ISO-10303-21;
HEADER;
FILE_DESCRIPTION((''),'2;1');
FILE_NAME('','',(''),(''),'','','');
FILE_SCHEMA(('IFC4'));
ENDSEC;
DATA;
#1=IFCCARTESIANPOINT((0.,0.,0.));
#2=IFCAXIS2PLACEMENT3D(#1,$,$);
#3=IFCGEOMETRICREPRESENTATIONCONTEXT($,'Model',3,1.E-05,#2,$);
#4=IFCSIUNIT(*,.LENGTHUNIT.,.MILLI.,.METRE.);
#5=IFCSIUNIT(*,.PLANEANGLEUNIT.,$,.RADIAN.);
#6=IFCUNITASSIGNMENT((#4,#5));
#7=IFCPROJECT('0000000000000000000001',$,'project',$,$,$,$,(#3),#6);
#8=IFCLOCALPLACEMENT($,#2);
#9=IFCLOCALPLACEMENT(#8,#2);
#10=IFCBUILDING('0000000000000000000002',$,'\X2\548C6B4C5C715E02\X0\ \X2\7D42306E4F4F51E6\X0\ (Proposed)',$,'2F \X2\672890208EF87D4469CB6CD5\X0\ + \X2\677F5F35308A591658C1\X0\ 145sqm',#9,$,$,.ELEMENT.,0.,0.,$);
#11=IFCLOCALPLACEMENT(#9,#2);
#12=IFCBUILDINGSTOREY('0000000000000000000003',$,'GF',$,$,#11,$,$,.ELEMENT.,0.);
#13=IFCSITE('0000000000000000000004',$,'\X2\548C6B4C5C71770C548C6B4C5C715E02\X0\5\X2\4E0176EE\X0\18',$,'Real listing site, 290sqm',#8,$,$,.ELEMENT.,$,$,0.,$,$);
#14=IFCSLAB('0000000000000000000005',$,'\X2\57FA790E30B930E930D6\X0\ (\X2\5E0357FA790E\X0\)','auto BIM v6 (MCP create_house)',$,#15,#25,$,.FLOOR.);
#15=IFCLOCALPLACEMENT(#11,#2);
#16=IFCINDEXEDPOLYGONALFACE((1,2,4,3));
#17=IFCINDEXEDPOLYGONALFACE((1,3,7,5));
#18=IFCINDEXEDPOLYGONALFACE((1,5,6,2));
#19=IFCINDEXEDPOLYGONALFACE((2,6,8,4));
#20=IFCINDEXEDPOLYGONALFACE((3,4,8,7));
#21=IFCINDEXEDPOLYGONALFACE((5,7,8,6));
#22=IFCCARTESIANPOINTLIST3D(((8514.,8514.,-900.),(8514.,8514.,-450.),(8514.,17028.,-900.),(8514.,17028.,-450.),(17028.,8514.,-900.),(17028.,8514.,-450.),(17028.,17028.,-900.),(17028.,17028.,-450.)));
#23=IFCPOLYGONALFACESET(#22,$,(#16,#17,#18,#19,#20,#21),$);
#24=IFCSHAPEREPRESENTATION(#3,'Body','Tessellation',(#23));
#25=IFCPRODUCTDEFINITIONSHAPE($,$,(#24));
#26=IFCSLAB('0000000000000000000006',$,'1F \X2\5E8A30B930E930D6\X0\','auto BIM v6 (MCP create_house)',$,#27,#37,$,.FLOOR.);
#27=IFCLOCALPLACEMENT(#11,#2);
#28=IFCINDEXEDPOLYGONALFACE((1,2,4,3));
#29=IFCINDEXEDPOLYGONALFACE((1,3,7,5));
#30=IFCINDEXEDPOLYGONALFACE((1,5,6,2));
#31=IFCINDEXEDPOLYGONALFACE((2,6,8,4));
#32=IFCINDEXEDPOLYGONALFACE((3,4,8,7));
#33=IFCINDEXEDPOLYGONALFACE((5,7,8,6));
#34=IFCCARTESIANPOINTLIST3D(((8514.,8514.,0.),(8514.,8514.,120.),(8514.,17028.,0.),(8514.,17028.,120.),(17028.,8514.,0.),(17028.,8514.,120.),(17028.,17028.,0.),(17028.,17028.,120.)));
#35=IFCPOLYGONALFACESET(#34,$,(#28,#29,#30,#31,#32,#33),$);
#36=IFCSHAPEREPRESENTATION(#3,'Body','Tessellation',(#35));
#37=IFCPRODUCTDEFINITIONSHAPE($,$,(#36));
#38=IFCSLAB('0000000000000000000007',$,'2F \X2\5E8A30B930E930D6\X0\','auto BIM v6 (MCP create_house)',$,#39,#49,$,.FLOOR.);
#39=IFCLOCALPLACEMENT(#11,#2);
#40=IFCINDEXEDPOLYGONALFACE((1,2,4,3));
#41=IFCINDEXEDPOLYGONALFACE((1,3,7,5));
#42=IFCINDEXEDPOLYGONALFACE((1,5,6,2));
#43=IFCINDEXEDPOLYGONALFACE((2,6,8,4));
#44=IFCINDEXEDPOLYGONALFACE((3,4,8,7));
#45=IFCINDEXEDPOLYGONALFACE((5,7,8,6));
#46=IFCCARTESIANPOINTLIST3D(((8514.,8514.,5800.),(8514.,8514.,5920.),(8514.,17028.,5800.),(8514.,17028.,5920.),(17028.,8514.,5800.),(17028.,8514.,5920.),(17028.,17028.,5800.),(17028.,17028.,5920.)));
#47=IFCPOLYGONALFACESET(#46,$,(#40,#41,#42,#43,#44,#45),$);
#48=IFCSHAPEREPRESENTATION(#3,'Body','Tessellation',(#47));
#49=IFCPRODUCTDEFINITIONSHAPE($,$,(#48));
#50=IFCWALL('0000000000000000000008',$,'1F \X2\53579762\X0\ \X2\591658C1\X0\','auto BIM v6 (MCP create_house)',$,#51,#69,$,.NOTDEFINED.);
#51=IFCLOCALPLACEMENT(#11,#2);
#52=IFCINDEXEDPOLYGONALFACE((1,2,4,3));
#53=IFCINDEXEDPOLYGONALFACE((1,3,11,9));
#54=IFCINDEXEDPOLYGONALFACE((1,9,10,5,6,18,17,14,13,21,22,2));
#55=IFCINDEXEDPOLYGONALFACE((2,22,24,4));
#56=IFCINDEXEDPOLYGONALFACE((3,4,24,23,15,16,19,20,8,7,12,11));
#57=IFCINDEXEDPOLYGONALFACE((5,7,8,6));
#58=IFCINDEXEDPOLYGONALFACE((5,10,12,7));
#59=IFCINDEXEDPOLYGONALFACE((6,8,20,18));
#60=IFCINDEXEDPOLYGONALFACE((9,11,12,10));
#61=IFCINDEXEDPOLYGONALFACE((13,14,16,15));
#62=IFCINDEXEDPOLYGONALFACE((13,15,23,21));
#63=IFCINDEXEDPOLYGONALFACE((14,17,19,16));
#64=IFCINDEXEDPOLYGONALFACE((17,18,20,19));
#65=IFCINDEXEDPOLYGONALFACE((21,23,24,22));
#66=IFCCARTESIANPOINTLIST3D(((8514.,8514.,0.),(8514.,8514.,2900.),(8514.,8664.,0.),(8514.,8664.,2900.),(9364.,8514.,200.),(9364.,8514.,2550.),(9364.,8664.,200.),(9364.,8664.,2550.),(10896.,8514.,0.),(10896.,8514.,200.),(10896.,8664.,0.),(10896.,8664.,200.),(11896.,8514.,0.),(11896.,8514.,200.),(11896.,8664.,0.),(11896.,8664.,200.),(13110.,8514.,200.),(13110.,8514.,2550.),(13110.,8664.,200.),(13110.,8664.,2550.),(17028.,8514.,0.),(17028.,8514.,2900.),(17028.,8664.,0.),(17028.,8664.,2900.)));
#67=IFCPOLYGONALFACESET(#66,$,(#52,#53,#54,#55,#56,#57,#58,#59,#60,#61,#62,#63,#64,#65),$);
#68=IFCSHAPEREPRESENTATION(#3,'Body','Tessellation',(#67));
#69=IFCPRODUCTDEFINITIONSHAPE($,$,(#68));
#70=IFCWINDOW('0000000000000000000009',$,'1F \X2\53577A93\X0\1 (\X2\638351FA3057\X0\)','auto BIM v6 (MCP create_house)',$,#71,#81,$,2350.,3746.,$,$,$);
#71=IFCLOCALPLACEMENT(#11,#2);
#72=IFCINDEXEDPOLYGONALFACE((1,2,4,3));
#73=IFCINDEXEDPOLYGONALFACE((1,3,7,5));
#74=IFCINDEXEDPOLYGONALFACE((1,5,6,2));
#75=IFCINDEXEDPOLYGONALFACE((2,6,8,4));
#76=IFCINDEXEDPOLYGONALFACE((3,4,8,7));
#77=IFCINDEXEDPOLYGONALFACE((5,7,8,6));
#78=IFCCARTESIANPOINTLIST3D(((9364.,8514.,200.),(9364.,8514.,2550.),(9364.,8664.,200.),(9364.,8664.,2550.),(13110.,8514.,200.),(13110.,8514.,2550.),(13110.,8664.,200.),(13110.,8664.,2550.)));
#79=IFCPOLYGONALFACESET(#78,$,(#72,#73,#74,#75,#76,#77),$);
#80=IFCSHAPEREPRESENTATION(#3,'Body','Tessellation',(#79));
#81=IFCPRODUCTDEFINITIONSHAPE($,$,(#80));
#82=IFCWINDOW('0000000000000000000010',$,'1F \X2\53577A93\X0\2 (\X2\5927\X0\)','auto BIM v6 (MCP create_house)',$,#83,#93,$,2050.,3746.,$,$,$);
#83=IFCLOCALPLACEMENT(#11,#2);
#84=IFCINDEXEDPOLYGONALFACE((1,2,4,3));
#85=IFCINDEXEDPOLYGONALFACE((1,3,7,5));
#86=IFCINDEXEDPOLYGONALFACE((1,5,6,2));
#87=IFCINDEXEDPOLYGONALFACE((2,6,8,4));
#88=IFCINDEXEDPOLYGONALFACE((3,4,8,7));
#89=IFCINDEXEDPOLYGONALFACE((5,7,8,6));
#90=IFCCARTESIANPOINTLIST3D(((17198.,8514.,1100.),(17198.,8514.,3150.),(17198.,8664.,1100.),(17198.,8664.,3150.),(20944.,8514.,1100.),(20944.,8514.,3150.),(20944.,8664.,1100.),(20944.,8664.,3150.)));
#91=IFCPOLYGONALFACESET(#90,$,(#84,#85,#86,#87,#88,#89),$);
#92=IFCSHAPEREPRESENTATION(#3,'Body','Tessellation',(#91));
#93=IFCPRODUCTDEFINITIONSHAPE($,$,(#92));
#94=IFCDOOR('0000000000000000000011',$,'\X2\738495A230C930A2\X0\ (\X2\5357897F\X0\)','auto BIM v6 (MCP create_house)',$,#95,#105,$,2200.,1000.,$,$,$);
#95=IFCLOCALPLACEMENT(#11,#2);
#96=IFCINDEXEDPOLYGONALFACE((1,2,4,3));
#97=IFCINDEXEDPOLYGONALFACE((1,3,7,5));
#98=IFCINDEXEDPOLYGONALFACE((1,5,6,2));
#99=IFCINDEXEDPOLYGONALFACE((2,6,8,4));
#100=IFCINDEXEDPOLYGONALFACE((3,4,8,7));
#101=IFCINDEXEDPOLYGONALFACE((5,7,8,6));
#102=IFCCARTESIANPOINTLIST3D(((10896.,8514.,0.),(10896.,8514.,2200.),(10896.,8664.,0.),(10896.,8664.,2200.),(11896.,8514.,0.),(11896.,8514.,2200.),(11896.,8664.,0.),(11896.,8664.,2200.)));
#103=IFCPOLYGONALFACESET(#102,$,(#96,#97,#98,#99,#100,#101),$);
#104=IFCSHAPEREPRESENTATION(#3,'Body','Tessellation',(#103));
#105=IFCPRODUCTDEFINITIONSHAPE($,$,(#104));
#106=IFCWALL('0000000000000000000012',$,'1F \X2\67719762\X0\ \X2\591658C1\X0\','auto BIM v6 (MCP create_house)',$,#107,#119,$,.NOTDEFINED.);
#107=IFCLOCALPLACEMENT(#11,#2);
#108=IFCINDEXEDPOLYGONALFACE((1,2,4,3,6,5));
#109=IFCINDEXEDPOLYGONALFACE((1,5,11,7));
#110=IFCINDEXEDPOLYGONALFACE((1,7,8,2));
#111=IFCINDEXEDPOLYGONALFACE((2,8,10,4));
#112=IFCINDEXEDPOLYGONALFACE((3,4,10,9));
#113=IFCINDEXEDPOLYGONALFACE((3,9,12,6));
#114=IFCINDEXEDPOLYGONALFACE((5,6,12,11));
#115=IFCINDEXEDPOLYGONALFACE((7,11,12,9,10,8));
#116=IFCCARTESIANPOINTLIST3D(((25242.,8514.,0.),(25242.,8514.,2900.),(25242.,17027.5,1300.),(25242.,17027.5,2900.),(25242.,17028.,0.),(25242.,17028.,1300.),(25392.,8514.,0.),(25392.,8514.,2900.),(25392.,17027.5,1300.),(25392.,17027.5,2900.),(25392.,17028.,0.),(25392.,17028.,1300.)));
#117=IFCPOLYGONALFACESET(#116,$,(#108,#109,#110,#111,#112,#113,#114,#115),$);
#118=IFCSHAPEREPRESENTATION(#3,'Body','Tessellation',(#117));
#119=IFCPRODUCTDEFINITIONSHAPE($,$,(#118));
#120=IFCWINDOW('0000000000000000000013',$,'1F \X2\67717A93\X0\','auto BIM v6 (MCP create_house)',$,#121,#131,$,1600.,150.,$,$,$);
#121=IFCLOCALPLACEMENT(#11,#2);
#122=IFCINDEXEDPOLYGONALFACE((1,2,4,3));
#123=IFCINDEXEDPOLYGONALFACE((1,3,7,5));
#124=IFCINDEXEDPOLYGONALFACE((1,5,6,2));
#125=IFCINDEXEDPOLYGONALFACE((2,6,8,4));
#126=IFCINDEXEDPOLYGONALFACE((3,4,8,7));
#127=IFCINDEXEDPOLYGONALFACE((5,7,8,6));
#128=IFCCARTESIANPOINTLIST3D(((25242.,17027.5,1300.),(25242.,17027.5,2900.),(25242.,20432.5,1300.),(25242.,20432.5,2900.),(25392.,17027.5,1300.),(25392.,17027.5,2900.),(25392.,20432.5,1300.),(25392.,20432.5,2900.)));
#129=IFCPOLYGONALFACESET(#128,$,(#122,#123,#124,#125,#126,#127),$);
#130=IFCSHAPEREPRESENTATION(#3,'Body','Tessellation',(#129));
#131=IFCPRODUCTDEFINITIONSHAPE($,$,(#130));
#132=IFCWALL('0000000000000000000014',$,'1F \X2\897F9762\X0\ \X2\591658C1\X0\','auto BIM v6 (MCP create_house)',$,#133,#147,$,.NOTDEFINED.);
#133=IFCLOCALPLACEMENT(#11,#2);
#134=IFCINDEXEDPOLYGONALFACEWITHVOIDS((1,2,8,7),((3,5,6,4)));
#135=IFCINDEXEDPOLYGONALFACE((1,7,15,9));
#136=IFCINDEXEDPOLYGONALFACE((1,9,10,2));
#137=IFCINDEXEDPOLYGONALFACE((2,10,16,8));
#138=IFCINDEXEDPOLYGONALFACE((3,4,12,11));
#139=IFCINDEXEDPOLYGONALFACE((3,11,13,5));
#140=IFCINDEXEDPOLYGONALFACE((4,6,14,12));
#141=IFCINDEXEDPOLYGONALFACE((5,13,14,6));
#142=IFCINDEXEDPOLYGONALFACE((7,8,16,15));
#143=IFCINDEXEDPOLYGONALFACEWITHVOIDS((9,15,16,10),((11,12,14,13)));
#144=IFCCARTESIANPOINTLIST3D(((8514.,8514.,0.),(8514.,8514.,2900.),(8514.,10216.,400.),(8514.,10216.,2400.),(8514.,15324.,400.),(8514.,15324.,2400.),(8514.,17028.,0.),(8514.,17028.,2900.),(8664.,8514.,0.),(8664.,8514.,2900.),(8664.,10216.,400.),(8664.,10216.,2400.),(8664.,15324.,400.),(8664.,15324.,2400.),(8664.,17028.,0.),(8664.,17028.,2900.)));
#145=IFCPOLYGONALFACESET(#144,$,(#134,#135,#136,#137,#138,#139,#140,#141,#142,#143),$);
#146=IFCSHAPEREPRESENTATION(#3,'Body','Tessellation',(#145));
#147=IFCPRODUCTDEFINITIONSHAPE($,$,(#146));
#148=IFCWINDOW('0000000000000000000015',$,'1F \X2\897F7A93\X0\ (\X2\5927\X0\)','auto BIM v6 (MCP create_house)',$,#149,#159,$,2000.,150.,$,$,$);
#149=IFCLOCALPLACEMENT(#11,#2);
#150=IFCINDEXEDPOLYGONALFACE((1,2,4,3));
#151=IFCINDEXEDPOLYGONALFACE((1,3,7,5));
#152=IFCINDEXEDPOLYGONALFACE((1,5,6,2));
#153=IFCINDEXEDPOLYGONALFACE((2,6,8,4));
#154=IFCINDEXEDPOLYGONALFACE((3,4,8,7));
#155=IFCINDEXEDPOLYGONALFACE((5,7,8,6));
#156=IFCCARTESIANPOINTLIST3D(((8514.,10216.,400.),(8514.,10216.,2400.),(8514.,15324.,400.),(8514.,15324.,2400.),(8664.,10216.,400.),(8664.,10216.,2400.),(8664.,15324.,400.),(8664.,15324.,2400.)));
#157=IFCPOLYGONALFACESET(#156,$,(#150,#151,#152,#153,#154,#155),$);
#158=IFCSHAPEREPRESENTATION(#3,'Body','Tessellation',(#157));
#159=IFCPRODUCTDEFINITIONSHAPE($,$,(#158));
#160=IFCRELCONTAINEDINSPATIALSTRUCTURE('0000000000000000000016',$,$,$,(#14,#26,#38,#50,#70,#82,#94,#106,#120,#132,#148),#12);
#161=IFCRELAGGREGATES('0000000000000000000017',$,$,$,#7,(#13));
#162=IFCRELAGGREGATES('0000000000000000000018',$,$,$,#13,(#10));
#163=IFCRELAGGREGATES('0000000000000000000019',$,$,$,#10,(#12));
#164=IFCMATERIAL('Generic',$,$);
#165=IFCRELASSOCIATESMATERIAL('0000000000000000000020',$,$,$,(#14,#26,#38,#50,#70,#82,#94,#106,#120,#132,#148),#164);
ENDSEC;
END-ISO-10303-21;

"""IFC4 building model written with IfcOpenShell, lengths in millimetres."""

from ifc_helpers import new_model, si_unit, frame, frame_2d, origin, place, context, project, spatial, rectangle, extrude, material, element, fill, save


model = new_model("IFC4")

# Units and contexts
model_context = context("Model", 3, precision=1e-05, world=origin())
ifc_project = project(units=[si_unit("LENGTHUNIT", "METRE", prefix="MILLI"), si_unit("PLANEANGLEUNIT", "RADIAN")], contexts=[model_context])

# Site, building, storey
site_placement = place(None, origin())
site = spatial("IfcSite", under=ifc_project, at=site_placement, Name="和歌山県和歌山市5丁目18", ObjectType="Real listing site, 290sqm", CompositionType="ELEMENT", RefElevation=0.0)
building_placement = place(site_placement, origin())
building = spatial("IfcBuilding", under=site, at=building_placement, Name="和歌山市 終の住処 (Proposed)", ObjectType="2F 木造軸組構法 + 板張り外壁 145sqm", CompositionType="ELEMENT", ElevationOfRefHeight=0.0, ElevationOfTerrain=0.0)
storey_placement = place(building_placement, origin())
storey = spatial("IfcBuildingStorey", under=building, at=storey_placement, Name="GF", CompositionType="ELEMENT", Elevation=0.0)

# Slabs
ifc_material = material(Name="Generic")
slab_1_placement = place(storey_placement, frame((4257.0, 4257.0, -450.0)))
element("IfcSlab", 1, at=slab_1_placement, inside=storey, material=ifc_material, Name="基礎スラブ (布基礎)", Description="auto BIM v6 (MCP create_house)", PredefinedType="FLOOR", context=model_context, shape_type="SweptSolid", body=[
    extrude(rectangle(XDim=8514.0, YDim=8514.0, at=frame_2d((4257.0, 4257.0))), frame((4257.0, 4257.0, -450.0)), (0.0, 0.0, 1.0), 450.0),
])
slab_2_placement = place(storey_placement, frame((4257.0, 4257.0, 0.0)))
element("IfcSlab", 2, at=slab_2_placement, inside=storey, material=ifc_material, Name="1F 床スラブ", Description="auto BIM v6 (MCP create_house)", PredefinedType="FLOOR", context=model_context, shape_type="SweptSolid", body=[
    extrude(rectangle(XDim=8514.0, YDim=8514.0, at=frame_2d((4257.0, 4257.0))), frame((4257.0, 4257.0, 0.0)), (0.0, 0.0, 1.0), 120.0),
])
slab_3_placement = place(storey_placement, frame((4257.0, 4257.0, 2900.0)))
element("IfcSlab", 3, at=slab_3_placement, inside=storey, material=ifc_material, Name="2F 床スラブ", Description="auto BIM v6 (MCP create_house)", PredefinedType="FLOOR", context=model_context, shape_type="SweptSolid", body=[
    extrude(rectangle(XDim=8514.0, YDim=8514.0, at=frame_2d((4257.0, 4257.0))), frame((4257.0, 4257.0, 2900.0)), (0.0, 0.0, 1.0), 120.0),
])

# Wall, openings, windows, door
wall_1_placement = place(storey_placement, frame((4257.0, 4257.0, 0.0)))
wall_1 = element("IfcWall", 4, at=wall_1_placement, inside=storey, material=ifc_material, Name="1F 南面 外壁", Description="auto BIM v6 (MCP create_house)", PredefinedType="NOTDEFINED", context=model_context, shape_type="SweptSolid", body=[
    extrude(rectangle(XDim=8514.0, YDim=150.0, at=frame_2d((4257.0, 75.0))), frame((4257.0, 4257.0, 0.0)), (0.0, 0.0, 1.0), 2900.0),
])
opening_1_placement = place(storey_placement, frame((4682.0, 4257.0, 100.0)))
opening_1 = element("IfcOpeningElement", 5, at=opening_1_placement, cuts=wall_1, PredefinedType="NOTDEFINED", context=model_context, shape_type="SweptSolid", body=[
    extrude(rectangle(XDim=3746.0, YDim=150.0, at=frame_2d((1873.0, 75.0))), frame((4682.0, 4257.0, 100.0)), (0.0, 0.0, 1.0), 2350.0),
])
opening_2_placement = place(storey_placement, frame((8599.0, 4257.0, 550.0)))
opening_2 = element("IfcOpeningElement", 6, at=opening_2_placement, cuts=wall_1, PredefinedType="NOTDEFINED", context=model_context, shape_type="SweptSolid", body=[
    extrude(rectangle(XDim=3746.0, YDim=150.0, at=frame_2d((1873.0, 75.0))), frame((8599.0, 4257.0, 550.0)), (0.0, 0.0, 1.0), 2050.0),
])
opening_3_placement = place(storey_placement, frame((5448.0, 4257.0, 0.0)))
opening_3 = element("IfcOpeningElement", 7, at=opening_3_placement, cuts=wall_1, PredefinedType="NOTDEFINED", context=model_context, shape_type="SweptSolid", body=[
    extrude(rectangle(XDim=1000.0, YDim=150.0, at=frame_2d((500.0, 75.0))), frame((5448.0, 4257.0, 0.0)), (0.0, 0.0, 1.0), 2200.0),
])
window_1_placement = place(storey_placement, frame((4682.0, 4257.0, 100.0)))
window_1 = element("IfcWindow", 8, at=window_1_placement, inside=storey, material=ifc_material, Name="1F 南窓1 (掃出し)", Description="auto BIM v6 (MCP create_house)", OverallHeight=2350.0, OverallWidth=3746.0, context=model_context, shape_type="SweptSolid", body=[
    extrude(rectangle(XDim=3746.0, YDim=150.0, at=frame_2d((1873.0, 75.0))), frame((4682.0, 4257.0, 100.0)), (0.0, 0.0, 1.0), 2350.0),
])
fill(opening_1, window_1)
window_2_placement = place(storey_placement, frame((8599.0, 4257.0, 550.0)))
window_2 = element("IfcWindow", 9, at=window_2_placement, inside=storey, material=ifc_material, Name="1F 南窓2 (大)", Description="auto BIM v6 (MCP create_house)", OverallHeight=2050.0, OverallWidth=3746.0, context=model_context, shape_type="SweptSolid", body=[
    extrude(rectangle(XDim=3746.0, YDim=150.0, at=frame_2d((1873.0, 75.0))), frame((8599.0, 4257.0, 550.0)), (0.0, 0.0, 1.0), 2050.0),
])
fill(opening_2, window_2)
door_placement = place(storey_placement, frame((5448.0, 4257.0, 0.0)))
door = element("IfcDoor", 10, at=door_placement, inside=storey, material=ifc_material, Name="玄関ドア (南西)", Description="auto BIM v6 (MCP create_house)", OverallHeight=2200.0, OverallWidth=1000.0, context=model_context, shape_type="SweptSolid", body=[
    extrude(rectangle(XDim=1000.0, YDim=150.0, at=frame_2d((500.0, 75.0))), frame((5448.0, 4257.0, 0.0)), (0.0, 0.0, 1.0), 2200.0),
])
fill(opening_3, door)

# Walls, openings, windows
wall_2_placement = place(storey_placement, frame((12621.0, 4257.0, 0.0)))
wall_2 = element("IfcWall", 11, at=wall_2_placement, inside=storey, material=ifc_material, Name="1F 東面 外壁", Description="auto BIM v6 (MCP create_house)", PredefinedType="NOTDEFINED", context=model_context, shape_type="SweptSolid", body=[
    extrude(rectangle(XDim=150.0, YDim=8514.0, at=frame_2d((75.0, 4257.0))), frame((12621.0, 4257.0, 0.0)), (0.0, 0.0, 1.0), 2900.0),
])
opening_4_placement = place(storey_placement, frame((12621.0, 8514.0, 650.0)))
opening_4 = element("IfcOpeningElement", 12, at=opening_4_placement, cuts=wall_2, PredefinedType="NOTDEFINED", context=model_context, shape_type="SweptSolid", body=[
    extrude(rectangle(XDim=150.0, YDim=3405.0, at=frame_2d((75.0, 1702.0))), frame((12621.0, 8514.0, 650.0)), (0.0, 0.0, 1.0), 1600.0),
])
window_3_placement = place(storey_placement, frame((12621.0, 8514.0, 650.0)))
window_3 = element("IfcWindow", 13, at=window_3_placement, inside=storey, material=ifc_material, Name="1F 東窓", Description="auto BIM v6 (MCP create_house)", OverallHeight=1600.0, OverallWidth=150.0, context=model_context, shape_type="SweptSolid", body=[
    extrude(rectangle(XDim=150.0, YDim=3405.0, at=frame_2d((75.0, 1702.0))), frame((12621.0, 8514.0, 650.0)), (0.0, 0.0, 1.0), 1600.0),
])
fill(opening_4, window_3)
wall_3_placement = place(storey_placement, frame((4257.0, 4257.0, 0.0)))
wall_3 = element("IfcWall", 14, at=wall_3_placement, inside=storey, material=ifc_material, Name="1F 西面 外壁", Description="auto BIM v6 (MCP create_house)", PredefinedType="NOTDEFINED", context=model_context, shape_type="SweptSolid", body=[
    extrude(rectangle(XDim=150.0, YDim=8514.0, at=frame_2d((75.0, 4257.0))), frame((4257.0, 4257.0, 0.0)), (0.0, 0.0, 1.0), 2900.0),
])
opening_5_placement = place(storey_placement, frame((4257.0, 5108.0, 200.0)))
opening_5 = element("IfcOpeningElement", 15, at=opening_5_placement, cuts=wall_3, PredefinedType="NOTDEFINED", context=model_context, shape_type="SweptSolid", body=[
    extrude(rectangle(XDim=150.0, YDim=5108.0, at=frame_2d((75.0, 2554.0))), frame((4257.0, 5108.0, 200.0)), (0.0, 0.0, 1.0), 2000.0),
])
window_4_placement = place(storey_placement, frame((4257.0, 5108.0, 200.0)))
window_4 = element("IfcWindow", 16, at=window_4_placement, inside=storey, material=ifc_material, Name="1F 西窓 (大)", Description="auto BIM v6 (MCP create_house)", OverallHeight=2000.0, OverallWidth=150.0, context=model_context, shape_type="SweptSolid", body=[
    extrude(rectangle(XDim=150.0, YDim=5108.0, at=frame_2d((75.0, 2554.0))), frame((4257.0, 5108.0, 200.0)), (0.0, 0.0, 1.0), 2000.0),
])
fill(opening_5, window_4)

save(model, "model.ifc")
